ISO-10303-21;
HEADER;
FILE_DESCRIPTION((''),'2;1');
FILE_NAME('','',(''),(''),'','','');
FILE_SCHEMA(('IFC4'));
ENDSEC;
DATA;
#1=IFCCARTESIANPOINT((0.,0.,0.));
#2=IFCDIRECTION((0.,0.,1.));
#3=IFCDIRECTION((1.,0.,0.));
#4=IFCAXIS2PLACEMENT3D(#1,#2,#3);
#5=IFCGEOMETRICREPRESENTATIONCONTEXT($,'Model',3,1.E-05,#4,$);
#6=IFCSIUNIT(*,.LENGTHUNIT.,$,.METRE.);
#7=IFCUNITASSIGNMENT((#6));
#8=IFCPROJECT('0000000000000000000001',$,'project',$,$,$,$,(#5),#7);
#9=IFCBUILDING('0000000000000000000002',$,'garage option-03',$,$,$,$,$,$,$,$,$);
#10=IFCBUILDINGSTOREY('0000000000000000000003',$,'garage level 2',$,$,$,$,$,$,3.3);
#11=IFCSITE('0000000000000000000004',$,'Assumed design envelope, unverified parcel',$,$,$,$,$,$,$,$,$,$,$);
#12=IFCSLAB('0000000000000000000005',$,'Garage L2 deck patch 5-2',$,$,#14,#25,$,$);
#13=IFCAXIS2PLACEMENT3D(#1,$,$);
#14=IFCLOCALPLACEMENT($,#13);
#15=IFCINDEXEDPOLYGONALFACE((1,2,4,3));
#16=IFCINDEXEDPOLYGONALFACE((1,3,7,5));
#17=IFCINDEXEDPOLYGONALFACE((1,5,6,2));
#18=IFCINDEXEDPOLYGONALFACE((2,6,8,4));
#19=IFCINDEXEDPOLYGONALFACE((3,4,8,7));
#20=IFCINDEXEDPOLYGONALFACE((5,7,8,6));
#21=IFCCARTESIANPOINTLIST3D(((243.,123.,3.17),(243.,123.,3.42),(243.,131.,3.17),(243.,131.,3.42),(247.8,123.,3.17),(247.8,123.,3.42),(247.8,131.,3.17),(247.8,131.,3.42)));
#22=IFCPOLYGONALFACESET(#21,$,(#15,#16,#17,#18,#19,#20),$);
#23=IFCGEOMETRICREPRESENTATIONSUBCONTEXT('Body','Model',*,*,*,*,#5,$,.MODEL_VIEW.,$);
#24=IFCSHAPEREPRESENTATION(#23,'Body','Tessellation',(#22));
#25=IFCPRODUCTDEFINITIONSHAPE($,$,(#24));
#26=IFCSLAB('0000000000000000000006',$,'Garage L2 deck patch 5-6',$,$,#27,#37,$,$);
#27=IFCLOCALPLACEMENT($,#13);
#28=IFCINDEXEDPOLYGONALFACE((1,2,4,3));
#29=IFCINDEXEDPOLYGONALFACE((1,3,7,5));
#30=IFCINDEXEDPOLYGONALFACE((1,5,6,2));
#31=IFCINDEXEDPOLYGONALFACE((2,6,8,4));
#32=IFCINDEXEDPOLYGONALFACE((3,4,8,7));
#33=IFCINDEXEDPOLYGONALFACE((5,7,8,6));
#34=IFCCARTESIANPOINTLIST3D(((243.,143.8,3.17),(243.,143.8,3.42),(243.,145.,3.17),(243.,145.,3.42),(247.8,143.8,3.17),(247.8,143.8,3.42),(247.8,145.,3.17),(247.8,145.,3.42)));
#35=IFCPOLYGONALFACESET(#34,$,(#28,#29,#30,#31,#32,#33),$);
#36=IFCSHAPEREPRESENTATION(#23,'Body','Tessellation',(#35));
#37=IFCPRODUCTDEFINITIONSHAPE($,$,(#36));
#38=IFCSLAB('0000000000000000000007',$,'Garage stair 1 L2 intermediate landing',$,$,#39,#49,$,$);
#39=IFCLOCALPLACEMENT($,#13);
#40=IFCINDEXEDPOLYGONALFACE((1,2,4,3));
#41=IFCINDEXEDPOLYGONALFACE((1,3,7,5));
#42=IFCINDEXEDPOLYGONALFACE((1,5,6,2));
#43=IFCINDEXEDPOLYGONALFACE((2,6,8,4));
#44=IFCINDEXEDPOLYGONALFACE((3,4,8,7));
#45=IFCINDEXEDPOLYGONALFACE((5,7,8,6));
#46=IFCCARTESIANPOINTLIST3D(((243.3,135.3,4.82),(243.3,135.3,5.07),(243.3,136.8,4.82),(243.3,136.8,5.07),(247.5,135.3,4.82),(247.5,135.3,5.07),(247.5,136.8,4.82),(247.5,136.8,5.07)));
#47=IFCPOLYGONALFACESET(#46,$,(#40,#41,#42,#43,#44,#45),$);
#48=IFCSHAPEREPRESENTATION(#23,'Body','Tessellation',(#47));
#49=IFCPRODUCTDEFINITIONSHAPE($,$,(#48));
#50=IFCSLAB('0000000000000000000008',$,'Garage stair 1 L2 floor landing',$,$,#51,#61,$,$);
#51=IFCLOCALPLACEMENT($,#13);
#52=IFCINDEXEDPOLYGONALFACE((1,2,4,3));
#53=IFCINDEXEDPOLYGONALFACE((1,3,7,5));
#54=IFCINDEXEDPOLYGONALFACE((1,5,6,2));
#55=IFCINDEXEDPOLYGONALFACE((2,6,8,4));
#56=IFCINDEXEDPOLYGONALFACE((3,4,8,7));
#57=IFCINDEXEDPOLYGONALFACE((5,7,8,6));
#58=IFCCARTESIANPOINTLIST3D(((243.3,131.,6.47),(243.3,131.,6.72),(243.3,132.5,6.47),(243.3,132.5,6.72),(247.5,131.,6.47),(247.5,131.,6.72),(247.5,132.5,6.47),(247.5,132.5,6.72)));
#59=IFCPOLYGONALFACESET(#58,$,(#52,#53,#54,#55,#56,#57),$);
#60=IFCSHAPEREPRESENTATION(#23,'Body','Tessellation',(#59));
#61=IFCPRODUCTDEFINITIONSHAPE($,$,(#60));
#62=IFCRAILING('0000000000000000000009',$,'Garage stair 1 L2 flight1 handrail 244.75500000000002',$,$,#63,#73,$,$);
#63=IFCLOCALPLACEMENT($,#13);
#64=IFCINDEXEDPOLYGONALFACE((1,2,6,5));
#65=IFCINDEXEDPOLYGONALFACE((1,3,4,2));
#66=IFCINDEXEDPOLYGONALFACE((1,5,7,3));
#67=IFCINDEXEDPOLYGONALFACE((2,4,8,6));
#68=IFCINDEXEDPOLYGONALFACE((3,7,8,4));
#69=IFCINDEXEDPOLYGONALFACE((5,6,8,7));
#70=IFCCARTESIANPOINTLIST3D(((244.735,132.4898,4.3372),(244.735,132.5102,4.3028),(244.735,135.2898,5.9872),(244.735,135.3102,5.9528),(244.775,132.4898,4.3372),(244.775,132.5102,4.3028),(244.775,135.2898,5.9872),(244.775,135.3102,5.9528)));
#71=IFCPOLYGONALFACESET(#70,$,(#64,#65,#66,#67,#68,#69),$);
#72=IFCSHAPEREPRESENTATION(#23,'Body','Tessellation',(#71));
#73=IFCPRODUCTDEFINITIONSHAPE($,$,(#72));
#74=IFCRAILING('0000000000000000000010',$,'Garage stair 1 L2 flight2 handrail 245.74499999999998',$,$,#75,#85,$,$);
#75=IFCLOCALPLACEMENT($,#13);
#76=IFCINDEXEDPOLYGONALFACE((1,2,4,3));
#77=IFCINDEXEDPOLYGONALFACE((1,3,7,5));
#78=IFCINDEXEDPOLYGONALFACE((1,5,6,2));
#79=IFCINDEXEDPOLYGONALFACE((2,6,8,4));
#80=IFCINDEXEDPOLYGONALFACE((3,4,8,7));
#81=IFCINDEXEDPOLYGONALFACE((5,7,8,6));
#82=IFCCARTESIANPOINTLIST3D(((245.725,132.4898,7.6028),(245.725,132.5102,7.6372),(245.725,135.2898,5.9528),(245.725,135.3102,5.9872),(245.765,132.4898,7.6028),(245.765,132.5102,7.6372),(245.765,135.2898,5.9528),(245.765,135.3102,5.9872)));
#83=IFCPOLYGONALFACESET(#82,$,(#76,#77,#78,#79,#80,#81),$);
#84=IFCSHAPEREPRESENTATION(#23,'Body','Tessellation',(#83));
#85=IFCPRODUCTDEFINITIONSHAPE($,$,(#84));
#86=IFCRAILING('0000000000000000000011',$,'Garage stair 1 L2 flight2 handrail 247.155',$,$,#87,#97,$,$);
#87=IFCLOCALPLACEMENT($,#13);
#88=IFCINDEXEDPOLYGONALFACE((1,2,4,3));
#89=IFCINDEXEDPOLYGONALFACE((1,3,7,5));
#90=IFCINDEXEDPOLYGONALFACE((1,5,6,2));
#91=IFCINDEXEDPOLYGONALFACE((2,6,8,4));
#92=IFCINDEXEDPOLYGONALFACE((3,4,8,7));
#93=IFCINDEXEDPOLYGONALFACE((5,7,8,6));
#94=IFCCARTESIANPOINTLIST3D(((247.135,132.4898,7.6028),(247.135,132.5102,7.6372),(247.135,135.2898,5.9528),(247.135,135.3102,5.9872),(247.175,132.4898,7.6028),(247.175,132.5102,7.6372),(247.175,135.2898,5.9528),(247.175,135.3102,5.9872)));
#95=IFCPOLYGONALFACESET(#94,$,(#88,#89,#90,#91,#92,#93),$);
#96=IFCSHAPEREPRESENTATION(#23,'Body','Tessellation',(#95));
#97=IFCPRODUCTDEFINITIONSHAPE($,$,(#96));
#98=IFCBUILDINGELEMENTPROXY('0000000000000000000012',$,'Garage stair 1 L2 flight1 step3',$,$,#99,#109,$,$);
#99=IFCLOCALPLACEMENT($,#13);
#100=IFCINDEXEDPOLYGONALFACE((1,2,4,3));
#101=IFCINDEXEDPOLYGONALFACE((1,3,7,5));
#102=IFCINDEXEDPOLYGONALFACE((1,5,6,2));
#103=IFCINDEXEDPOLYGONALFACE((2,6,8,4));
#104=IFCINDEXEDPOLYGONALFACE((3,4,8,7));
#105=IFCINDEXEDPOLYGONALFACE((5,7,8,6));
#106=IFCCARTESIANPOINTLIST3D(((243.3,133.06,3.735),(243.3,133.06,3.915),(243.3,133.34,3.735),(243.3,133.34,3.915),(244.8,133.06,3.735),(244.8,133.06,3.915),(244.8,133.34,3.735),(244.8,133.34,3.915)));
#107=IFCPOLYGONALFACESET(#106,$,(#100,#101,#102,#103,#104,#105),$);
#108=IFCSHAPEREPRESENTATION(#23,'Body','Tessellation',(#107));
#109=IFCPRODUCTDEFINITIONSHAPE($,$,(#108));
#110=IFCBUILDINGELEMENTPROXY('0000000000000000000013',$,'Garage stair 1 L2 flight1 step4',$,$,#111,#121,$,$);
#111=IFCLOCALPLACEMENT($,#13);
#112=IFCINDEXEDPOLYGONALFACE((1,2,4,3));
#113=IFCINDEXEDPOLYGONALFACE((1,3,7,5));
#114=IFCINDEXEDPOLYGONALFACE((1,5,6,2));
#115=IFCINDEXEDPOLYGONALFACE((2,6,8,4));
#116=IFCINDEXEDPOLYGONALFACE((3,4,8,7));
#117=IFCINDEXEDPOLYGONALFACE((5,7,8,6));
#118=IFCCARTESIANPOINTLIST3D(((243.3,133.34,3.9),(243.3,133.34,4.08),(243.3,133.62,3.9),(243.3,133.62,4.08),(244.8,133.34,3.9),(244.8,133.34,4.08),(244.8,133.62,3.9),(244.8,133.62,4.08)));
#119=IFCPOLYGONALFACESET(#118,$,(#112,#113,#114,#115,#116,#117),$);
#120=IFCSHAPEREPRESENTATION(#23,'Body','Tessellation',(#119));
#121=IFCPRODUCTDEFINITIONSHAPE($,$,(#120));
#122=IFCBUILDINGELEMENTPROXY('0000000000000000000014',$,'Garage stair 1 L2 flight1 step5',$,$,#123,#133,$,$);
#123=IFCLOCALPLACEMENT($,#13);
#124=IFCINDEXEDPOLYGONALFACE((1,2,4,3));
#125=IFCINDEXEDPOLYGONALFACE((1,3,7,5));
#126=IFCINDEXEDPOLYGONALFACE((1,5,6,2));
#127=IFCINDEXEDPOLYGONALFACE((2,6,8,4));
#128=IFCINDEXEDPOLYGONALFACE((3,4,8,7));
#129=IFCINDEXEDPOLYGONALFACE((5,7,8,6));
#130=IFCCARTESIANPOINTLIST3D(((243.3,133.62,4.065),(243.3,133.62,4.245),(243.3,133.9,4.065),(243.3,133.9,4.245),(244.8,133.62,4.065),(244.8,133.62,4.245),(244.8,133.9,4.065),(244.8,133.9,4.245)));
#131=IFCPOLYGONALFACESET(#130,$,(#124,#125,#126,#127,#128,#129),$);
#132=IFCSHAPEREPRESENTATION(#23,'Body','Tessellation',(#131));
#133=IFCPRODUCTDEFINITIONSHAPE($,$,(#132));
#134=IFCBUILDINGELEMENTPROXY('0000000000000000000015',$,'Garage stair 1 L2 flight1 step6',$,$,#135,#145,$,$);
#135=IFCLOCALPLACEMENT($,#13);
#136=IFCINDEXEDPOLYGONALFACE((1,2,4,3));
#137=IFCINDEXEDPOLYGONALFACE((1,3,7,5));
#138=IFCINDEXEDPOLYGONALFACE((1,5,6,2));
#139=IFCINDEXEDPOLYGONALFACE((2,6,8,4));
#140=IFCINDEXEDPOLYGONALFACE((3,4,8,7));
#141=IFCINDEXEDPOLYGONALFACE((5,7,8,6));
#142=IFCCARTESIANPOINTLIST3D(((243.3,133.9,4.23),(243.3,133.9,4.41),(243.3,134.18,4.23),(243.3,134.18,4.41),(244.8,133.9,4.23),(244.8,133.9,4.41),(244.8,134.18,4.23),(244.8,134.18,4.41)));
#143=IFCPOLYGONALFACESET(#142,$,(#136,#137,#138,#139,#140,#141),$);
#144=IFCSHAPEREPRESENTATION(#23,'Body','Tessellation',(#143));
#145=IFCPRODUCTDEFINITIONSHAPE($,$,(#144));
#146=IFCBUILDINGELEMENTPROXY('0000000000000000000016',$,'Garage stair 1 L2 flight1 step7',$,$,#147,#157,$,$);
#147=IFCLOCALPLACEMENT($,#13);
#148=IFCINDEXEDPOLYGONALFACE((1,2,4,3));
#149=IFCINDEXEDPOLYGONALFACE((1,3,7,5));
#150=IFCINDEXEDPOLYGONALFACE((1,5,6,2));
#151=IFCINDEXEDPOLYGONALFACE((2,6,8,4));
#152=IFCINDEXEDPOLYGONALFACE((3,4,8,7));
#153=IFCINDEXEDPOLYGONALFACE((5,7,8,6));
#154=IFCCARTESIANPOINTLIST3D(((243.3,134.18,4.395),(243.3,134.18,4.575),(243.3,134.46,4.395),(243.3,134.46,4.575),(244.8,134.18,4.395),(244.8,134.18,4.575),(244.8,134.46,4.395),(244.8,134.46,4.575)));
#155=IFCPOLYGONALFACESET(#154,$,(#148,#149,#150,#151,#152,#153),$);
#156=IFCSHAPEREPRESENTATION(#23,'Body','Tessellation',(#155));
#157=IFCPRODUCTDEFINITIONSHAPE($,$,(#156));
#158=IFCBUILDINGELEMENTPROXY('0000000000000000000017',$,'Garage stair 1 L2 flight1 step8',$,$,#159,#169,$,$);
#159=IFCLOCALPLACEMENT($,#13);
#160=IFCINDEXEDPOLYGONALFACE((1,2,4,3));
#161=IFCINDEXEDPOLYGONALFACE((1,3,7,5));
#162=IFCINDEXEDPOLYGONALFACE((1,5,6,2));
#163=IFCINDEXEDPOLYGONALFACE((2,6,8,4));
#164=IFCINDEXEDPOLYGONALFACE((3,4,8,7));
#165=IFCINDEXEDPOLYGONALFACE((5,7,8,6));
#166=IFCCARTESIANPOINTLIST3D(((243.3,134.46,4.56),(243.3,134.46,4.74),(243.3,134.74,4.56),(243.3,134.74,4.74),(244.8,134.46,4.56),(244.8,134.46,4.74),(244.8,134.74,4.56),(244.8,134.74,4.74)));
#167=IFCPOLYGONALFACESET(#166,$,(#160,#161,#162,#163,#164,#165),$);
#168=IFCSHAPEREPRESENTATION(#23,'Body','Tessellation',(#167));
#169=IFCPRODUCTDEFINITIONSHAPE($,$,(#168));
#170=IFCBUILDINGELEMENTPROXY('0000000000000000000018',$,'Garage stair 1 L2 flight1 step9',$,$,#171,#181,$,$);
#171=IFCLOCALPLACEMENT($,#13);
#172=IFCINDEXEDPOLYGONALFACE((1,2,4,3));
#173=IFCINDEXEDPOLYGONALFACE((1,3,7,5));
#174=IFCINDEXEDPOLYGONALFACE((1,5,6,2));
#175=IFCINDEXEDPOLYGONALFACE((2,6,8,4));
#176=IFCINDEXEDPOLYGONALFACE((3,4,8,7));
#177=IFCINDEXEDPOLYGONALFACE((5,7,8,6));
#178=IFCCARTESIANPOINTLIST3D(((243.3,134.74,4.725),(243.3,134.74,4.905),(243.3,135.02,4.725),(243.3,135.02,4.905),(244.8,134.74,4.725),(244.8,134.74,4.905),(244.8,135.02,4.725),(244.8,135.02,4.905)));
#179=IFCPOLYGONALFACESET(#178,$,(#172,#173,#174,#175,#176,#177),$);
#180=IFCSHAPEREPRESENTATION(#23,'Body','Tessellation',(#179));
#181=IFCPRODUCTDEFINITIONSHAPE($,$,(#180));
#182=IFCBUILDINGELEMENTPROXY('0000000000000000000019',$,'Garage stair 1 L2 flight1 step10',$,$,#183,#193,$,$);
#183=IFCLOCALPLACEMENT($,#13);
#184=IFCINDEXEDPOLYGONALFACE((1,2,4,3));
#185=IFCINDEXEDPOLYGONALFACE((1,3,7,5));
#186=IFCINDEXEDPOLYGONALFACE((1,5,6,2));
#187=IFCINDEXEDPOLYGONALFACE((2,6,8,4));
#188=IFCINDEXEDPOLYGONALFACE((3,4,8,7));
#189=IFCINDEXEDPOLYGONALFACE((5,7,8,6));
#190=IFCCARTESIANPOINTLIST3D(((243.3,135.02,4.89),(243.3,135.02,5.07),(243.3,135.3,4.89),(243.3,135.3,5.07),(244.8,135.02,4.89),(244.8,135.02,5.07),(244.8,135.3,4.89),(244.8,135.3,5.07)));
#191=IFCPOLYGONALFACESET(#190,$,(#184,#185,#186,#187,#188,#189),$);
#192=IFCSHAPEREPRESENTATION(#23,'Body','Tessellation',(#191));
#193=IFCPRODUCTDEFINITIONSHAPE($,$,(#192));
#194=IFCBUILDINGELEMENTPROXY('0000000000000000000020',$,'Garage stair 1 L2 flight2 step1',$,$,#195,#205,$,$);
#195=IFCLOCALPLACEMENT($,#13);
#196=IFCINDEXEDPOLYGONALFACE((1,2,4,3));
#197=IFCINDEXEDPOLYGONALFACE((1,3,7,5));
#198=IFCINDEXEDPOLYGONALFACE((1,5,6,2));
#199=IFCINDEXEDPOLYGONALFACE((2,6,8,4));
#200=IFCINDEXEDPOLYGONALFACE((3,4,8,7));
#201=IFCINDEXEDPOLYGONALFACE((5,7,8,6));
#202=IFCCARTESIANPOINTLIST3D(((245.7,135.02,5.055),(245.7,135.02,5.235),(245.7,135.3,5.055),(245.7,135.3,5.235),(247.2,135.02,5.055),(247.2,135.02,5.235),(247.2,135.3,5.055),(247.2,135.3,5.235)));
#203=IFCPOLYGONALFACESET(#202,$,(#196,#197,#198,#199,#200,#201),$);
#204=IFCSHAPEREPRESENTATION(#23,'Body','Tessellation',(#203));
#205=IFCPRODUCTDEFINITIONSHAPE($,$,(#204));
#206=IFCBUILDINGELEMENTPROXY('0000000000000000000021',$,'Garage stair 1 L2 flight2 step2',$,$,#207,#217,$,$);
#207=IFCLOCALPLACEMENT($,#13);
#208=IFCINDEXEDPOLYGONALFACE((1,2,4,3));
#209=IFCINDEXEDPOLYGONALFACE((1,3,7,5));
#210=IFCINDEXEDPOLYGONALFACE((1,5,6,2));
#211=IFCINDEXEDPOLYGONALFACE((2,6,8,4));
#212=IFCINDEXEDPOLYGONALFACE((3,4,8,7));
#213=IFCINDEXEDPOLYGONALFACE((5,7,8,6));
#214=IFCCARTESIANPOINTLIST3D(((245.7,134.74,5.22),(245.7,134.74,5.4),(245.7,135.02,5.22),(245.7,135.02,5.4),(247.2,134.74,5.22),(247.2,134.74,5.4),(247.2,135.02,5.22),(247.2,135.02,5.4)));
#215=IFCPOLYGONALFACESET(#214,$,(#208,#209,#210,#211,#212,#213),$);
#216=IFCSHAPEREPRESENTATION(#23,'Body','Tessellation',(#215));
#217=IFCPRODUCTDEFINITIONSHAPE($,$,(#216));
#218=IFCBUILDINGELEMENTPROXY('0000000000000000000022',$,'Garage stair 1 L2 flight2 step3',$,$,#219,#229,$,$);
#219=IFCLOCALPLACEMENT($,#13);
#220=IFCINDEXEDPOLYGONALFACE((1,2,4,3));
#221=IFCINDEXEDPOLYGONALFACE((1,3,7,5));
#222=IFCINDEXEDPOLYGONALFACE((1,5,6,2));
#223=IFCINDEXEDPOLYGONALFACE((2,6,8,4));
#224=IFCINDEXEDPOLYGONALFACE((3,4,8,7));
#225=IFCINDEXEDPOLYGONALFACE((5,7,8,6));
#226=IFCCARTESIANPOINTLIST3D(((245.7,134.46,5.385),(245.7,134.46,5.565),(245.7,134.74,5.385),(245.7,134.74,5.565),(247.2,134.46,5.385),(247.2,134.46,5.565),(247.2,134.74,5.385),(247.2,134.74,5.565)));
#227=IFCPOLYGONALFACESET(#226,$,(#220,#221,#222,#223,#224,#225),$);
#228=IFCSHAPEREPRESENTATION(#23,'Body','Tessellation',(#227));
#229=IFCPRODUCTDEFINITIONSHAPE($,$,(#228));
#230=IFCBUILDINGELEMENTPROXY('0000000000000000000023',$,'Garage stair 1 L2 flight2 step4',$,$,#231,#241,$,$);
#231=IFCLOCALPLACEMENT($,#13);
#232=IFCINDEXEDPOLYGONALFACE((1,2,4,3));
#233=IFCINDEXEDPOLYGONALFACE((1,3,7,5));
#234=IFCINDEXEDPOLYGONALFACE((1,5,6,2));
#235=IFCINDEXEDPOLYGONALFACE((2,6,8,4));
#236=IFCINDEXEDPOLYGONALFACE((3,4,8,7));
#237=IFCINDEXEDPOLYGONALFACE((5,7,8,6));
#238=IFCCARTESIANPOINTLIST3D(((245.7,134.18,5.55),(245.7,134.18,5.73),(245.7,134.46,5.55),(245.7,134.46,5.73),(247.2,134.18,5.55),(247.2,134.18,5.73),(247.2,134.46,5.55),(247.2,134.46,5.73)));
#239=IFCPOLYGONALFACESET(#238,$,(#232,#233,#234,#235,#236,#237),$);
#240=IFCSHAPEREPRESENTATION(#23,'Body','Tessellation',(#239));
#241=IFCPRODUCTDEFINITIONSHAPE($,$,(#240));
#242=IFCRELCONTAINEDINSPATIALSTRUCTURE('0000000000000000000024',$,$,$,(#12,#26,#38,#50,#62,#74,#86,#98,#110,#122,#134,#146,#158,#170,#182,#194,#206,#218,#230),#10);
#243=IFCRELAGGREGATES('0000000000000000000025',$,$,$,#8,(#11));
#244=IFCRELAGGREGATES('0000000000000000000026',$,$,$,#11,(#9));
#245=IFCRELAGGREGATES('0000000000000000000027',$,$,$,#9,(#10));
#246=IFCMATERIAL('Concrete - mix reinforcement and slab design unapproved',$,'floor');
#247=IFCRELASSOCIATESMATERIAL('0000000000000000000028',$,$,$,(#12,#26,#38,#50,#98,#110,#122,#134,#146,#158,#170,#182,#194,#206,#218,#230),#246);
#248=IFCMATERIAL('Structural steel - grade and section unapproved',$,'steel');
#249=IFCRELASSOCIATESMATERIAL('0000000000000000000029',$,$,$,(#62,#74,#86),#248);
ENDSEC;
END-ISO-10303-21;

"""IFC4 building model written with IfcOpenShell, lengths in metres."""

from ifc_helpers import new_model, si_unit, frame, origin_with_axes, place, context, subcontext, project, spatial, rectangle, extrude, material, element, save


model = new_model("IFC4")

# Units and contexts
model_context = context("Model", 3, precision=1e-05, world=origin_with_axes())
body_context = subcontext(model_context, "Body", "Model", "MODEL_VIEW")
ifc_project = project(units=[si_unit("LENGTHUNIT", "METRE")], contexts=[model_context])

# Site, building, storey
site = spatial("IfcSite", under=ifc_project, Name="Assumed design envelope, unverified parcel")
building = spatial("IfcBuilding", under=site, Name="garage option-03")
storey = spatial("IfcBuildingStorey", under=building, Name="garage level 2", Elevation=3.3)

# Slabs
ifc_material_1 = material(Name="Concrete - mix reinforcement and slab design unapproved", Category="floor")
slab_1_placement = place(None, frame((245.4, 127.0, 3.17), z_axis=(0.0, 0.0, 1.0), x_axis=(1.0, 0.0, 0.0)))
element("IfcSlab", 1, at=slab_1_placement, inside=storey, material=ifc_material_1, Name="Garage L2 deck patch 5-2", context=body_context, shape_type="SweptSolid", body=[
    extrude(rectangle(XDim=4.8, YDim=8.0), origin_with_axes(), (0.0, 0.0, 1.0), 0.25),
])
slab_2_placement = place(None, frame((245.4, 144.4, 3.17), z_axis=(0.0, 0.0, 1.0), x_axis=(1.0, 0.0, 0.0)))
element("IfcSlab", 2, at=slab_2_placement, inside=storey, material=ifc_material_1, Name="Garage L2 deck patch 5-6", context=body_context, shape_type="SweptSolid", body=[
    extrude(rectangle(XDim=4.8, YDim=1.2), origin_with_axes(), (0.0, 0.0, 1.0), 0.25),
])
for number, where, z_axis, x_axis, name in (
    (3, (245.4, 136.05, 4.82), (0.0, 0.0, 1.0), (1.0, 0.0, 0.0), "Garage stair 1 L2 intermediate landing"),
    (4, (245.4, 131.75, 6.47), (0.0, 0.0, 1.0), (1.0, 0.0, 0.0), "Garage stair 1 L2 floor landing"),
):
    element("IfcSlab", number, at=place(None, frame(where, z_axis=z_axis, x_axis=x_axis)), inside=storey, material=ifc_material_1, Name=name, context=body_context, shape_type="SweptSolid", body=[
        extrude(rectangle(XDim=4.2, YDim=1.5), origin_with_axes(), (0.0, 0.0, 1.0), 0.25),
    ])

# Railings
ifc_material_2 = material(Name="Structural steel - grade and section unapproved", Category="steel")
railing_placement = place(None, frame((244.755, 132.5, 4.32), z_axis=(0.0, 0.861539, 0.507692), x_axis=(-1.0, 0.0, 0.0)))
element("IfcRailing", 5, at=railing_placement, inside=storey, material=ifc_material_2, Name="Garage stair 1 L2 flight1 handrail 244.75500000000002", context=body_context, shape_type="SweptSolid", body=[
    extrude(rectangle(XDim=0.04, YDim=0.04), origin_with_axes(), (0.0, 0.0, 1.0), 3.25),
])
for number, where, z_axis, x_axis, name in (
    (6, (245.745, 132.5, 7.62), (0.0, 0.861539, -0.507692), (-1.0, 0.0, 0.0), "Garage stair 1 L2 flight2 handrail 245.74499999999998"),
    (7, (247.155, 132.5, 7.62), (0.0, 0.861539, -0.507692), (-1.0, 0.0, 0.0), "Garage stair 1 L2 flight2 handrail 247.155"),
):
    element("IfcRailing", number, at=place(None, frame(where, z_axis=z_axis, x_axis=x_axis)), inside=storey, material=ifc_material_2, Name=name, context=body_context, shape_type="SweptSolid", body=[
        extrude(rectangle(XDim=0.04, YDim=0.04), origin_with_axes(), (0.0, 0.0, 1.0), 3.25),
    ])

# Building element proxies
for number, where, z_axis, x_axis, name in (
    (8, (244.05, 133.2, 3.735), (0.0, 0.0, 1.0), (1.0, 0.0, 0.0), "Garage stair 1 L2 flight1 step3"),
    (9, (244.05, 133.48, 3.9), (0.0, 0.0, 1.0), (1.0, 0.0, 0.0), "Garage stair 1 L2 flight1 step4"),
    (10, (244.05, 133.76, 4.065), (0.0, 0.0, 1.0), (1.0, 0.0, 0.0), "Garage stair 1 L2 flight1 step5"),
    (11, (244.05, 134.04, 4.23), (0.0, 0.0, 1.0), (1.0, 0.0, 0.0), "Garage stair 1 L2 flight1 step6"),
    (12, (244.05, 134.32, 4.395), (0.0, 0.0, 1.0), (1.0, 0.0, 0.0), "Garage stair 1 L2 flight1 step7"),
    (13, (244.05, 134.6, 4.56), (0.0, 0.0, 1.0), (1.0, 0.0, 0.0), "Garage stair 1 L2 flight1 step8"),
    (14, (244.05, 134.88, 4.725), (0.0, 0.0, 1.0), (1.0, 0.0, 0.0), "Garage stair 1 L2 flight1 step9"),
    (15, (244.05, 135.16, 4.89), (0.0, 0.0, 1.0), (1.0, 0.0, 0.0), "Garage stair 1 L2 flight1 step10"),
    (16, (246.45, 135.16, 5.055), (0.0, 0.0, 1.0), (1.0, 0.0, 0.0), "Garage stair 1 L2 flight2 step1"),
    (17, (246.45, 134.88, 5.22), (0.0, 0.0, 1.0), (1.0, 0.0, 0.0), "Garage stair 1 L2 flight2 step2"),
    (18, (246.45, 134.6, 5.385), (0.0, 0.0, 1.0), (1.0, 0.0, 0.0), "Garage stair 1 L2 flight2 step3"),
    (19, (246.45, 134.32, 5.55), (0.0, 0.0, 1.0), (1.0, 0.0, 0.0), "Garage stair 1 L2 flight2 step4"),
):
    element("IfcBuildingElementProxy", number, at=place(None, frame(where, z_axis=z_axis, x_axis=x_axis)), inside=storey, material=ifc_material_1, Name=name, context=body_context, shape_type="SweptSolid", body=[
        extrude(rectangle(XDim=1.5, YDim=0.28), origin_with_axes(), (0.0, 0.0, 1.0), 0.18),
    ])

save(model, "model.ifc")
